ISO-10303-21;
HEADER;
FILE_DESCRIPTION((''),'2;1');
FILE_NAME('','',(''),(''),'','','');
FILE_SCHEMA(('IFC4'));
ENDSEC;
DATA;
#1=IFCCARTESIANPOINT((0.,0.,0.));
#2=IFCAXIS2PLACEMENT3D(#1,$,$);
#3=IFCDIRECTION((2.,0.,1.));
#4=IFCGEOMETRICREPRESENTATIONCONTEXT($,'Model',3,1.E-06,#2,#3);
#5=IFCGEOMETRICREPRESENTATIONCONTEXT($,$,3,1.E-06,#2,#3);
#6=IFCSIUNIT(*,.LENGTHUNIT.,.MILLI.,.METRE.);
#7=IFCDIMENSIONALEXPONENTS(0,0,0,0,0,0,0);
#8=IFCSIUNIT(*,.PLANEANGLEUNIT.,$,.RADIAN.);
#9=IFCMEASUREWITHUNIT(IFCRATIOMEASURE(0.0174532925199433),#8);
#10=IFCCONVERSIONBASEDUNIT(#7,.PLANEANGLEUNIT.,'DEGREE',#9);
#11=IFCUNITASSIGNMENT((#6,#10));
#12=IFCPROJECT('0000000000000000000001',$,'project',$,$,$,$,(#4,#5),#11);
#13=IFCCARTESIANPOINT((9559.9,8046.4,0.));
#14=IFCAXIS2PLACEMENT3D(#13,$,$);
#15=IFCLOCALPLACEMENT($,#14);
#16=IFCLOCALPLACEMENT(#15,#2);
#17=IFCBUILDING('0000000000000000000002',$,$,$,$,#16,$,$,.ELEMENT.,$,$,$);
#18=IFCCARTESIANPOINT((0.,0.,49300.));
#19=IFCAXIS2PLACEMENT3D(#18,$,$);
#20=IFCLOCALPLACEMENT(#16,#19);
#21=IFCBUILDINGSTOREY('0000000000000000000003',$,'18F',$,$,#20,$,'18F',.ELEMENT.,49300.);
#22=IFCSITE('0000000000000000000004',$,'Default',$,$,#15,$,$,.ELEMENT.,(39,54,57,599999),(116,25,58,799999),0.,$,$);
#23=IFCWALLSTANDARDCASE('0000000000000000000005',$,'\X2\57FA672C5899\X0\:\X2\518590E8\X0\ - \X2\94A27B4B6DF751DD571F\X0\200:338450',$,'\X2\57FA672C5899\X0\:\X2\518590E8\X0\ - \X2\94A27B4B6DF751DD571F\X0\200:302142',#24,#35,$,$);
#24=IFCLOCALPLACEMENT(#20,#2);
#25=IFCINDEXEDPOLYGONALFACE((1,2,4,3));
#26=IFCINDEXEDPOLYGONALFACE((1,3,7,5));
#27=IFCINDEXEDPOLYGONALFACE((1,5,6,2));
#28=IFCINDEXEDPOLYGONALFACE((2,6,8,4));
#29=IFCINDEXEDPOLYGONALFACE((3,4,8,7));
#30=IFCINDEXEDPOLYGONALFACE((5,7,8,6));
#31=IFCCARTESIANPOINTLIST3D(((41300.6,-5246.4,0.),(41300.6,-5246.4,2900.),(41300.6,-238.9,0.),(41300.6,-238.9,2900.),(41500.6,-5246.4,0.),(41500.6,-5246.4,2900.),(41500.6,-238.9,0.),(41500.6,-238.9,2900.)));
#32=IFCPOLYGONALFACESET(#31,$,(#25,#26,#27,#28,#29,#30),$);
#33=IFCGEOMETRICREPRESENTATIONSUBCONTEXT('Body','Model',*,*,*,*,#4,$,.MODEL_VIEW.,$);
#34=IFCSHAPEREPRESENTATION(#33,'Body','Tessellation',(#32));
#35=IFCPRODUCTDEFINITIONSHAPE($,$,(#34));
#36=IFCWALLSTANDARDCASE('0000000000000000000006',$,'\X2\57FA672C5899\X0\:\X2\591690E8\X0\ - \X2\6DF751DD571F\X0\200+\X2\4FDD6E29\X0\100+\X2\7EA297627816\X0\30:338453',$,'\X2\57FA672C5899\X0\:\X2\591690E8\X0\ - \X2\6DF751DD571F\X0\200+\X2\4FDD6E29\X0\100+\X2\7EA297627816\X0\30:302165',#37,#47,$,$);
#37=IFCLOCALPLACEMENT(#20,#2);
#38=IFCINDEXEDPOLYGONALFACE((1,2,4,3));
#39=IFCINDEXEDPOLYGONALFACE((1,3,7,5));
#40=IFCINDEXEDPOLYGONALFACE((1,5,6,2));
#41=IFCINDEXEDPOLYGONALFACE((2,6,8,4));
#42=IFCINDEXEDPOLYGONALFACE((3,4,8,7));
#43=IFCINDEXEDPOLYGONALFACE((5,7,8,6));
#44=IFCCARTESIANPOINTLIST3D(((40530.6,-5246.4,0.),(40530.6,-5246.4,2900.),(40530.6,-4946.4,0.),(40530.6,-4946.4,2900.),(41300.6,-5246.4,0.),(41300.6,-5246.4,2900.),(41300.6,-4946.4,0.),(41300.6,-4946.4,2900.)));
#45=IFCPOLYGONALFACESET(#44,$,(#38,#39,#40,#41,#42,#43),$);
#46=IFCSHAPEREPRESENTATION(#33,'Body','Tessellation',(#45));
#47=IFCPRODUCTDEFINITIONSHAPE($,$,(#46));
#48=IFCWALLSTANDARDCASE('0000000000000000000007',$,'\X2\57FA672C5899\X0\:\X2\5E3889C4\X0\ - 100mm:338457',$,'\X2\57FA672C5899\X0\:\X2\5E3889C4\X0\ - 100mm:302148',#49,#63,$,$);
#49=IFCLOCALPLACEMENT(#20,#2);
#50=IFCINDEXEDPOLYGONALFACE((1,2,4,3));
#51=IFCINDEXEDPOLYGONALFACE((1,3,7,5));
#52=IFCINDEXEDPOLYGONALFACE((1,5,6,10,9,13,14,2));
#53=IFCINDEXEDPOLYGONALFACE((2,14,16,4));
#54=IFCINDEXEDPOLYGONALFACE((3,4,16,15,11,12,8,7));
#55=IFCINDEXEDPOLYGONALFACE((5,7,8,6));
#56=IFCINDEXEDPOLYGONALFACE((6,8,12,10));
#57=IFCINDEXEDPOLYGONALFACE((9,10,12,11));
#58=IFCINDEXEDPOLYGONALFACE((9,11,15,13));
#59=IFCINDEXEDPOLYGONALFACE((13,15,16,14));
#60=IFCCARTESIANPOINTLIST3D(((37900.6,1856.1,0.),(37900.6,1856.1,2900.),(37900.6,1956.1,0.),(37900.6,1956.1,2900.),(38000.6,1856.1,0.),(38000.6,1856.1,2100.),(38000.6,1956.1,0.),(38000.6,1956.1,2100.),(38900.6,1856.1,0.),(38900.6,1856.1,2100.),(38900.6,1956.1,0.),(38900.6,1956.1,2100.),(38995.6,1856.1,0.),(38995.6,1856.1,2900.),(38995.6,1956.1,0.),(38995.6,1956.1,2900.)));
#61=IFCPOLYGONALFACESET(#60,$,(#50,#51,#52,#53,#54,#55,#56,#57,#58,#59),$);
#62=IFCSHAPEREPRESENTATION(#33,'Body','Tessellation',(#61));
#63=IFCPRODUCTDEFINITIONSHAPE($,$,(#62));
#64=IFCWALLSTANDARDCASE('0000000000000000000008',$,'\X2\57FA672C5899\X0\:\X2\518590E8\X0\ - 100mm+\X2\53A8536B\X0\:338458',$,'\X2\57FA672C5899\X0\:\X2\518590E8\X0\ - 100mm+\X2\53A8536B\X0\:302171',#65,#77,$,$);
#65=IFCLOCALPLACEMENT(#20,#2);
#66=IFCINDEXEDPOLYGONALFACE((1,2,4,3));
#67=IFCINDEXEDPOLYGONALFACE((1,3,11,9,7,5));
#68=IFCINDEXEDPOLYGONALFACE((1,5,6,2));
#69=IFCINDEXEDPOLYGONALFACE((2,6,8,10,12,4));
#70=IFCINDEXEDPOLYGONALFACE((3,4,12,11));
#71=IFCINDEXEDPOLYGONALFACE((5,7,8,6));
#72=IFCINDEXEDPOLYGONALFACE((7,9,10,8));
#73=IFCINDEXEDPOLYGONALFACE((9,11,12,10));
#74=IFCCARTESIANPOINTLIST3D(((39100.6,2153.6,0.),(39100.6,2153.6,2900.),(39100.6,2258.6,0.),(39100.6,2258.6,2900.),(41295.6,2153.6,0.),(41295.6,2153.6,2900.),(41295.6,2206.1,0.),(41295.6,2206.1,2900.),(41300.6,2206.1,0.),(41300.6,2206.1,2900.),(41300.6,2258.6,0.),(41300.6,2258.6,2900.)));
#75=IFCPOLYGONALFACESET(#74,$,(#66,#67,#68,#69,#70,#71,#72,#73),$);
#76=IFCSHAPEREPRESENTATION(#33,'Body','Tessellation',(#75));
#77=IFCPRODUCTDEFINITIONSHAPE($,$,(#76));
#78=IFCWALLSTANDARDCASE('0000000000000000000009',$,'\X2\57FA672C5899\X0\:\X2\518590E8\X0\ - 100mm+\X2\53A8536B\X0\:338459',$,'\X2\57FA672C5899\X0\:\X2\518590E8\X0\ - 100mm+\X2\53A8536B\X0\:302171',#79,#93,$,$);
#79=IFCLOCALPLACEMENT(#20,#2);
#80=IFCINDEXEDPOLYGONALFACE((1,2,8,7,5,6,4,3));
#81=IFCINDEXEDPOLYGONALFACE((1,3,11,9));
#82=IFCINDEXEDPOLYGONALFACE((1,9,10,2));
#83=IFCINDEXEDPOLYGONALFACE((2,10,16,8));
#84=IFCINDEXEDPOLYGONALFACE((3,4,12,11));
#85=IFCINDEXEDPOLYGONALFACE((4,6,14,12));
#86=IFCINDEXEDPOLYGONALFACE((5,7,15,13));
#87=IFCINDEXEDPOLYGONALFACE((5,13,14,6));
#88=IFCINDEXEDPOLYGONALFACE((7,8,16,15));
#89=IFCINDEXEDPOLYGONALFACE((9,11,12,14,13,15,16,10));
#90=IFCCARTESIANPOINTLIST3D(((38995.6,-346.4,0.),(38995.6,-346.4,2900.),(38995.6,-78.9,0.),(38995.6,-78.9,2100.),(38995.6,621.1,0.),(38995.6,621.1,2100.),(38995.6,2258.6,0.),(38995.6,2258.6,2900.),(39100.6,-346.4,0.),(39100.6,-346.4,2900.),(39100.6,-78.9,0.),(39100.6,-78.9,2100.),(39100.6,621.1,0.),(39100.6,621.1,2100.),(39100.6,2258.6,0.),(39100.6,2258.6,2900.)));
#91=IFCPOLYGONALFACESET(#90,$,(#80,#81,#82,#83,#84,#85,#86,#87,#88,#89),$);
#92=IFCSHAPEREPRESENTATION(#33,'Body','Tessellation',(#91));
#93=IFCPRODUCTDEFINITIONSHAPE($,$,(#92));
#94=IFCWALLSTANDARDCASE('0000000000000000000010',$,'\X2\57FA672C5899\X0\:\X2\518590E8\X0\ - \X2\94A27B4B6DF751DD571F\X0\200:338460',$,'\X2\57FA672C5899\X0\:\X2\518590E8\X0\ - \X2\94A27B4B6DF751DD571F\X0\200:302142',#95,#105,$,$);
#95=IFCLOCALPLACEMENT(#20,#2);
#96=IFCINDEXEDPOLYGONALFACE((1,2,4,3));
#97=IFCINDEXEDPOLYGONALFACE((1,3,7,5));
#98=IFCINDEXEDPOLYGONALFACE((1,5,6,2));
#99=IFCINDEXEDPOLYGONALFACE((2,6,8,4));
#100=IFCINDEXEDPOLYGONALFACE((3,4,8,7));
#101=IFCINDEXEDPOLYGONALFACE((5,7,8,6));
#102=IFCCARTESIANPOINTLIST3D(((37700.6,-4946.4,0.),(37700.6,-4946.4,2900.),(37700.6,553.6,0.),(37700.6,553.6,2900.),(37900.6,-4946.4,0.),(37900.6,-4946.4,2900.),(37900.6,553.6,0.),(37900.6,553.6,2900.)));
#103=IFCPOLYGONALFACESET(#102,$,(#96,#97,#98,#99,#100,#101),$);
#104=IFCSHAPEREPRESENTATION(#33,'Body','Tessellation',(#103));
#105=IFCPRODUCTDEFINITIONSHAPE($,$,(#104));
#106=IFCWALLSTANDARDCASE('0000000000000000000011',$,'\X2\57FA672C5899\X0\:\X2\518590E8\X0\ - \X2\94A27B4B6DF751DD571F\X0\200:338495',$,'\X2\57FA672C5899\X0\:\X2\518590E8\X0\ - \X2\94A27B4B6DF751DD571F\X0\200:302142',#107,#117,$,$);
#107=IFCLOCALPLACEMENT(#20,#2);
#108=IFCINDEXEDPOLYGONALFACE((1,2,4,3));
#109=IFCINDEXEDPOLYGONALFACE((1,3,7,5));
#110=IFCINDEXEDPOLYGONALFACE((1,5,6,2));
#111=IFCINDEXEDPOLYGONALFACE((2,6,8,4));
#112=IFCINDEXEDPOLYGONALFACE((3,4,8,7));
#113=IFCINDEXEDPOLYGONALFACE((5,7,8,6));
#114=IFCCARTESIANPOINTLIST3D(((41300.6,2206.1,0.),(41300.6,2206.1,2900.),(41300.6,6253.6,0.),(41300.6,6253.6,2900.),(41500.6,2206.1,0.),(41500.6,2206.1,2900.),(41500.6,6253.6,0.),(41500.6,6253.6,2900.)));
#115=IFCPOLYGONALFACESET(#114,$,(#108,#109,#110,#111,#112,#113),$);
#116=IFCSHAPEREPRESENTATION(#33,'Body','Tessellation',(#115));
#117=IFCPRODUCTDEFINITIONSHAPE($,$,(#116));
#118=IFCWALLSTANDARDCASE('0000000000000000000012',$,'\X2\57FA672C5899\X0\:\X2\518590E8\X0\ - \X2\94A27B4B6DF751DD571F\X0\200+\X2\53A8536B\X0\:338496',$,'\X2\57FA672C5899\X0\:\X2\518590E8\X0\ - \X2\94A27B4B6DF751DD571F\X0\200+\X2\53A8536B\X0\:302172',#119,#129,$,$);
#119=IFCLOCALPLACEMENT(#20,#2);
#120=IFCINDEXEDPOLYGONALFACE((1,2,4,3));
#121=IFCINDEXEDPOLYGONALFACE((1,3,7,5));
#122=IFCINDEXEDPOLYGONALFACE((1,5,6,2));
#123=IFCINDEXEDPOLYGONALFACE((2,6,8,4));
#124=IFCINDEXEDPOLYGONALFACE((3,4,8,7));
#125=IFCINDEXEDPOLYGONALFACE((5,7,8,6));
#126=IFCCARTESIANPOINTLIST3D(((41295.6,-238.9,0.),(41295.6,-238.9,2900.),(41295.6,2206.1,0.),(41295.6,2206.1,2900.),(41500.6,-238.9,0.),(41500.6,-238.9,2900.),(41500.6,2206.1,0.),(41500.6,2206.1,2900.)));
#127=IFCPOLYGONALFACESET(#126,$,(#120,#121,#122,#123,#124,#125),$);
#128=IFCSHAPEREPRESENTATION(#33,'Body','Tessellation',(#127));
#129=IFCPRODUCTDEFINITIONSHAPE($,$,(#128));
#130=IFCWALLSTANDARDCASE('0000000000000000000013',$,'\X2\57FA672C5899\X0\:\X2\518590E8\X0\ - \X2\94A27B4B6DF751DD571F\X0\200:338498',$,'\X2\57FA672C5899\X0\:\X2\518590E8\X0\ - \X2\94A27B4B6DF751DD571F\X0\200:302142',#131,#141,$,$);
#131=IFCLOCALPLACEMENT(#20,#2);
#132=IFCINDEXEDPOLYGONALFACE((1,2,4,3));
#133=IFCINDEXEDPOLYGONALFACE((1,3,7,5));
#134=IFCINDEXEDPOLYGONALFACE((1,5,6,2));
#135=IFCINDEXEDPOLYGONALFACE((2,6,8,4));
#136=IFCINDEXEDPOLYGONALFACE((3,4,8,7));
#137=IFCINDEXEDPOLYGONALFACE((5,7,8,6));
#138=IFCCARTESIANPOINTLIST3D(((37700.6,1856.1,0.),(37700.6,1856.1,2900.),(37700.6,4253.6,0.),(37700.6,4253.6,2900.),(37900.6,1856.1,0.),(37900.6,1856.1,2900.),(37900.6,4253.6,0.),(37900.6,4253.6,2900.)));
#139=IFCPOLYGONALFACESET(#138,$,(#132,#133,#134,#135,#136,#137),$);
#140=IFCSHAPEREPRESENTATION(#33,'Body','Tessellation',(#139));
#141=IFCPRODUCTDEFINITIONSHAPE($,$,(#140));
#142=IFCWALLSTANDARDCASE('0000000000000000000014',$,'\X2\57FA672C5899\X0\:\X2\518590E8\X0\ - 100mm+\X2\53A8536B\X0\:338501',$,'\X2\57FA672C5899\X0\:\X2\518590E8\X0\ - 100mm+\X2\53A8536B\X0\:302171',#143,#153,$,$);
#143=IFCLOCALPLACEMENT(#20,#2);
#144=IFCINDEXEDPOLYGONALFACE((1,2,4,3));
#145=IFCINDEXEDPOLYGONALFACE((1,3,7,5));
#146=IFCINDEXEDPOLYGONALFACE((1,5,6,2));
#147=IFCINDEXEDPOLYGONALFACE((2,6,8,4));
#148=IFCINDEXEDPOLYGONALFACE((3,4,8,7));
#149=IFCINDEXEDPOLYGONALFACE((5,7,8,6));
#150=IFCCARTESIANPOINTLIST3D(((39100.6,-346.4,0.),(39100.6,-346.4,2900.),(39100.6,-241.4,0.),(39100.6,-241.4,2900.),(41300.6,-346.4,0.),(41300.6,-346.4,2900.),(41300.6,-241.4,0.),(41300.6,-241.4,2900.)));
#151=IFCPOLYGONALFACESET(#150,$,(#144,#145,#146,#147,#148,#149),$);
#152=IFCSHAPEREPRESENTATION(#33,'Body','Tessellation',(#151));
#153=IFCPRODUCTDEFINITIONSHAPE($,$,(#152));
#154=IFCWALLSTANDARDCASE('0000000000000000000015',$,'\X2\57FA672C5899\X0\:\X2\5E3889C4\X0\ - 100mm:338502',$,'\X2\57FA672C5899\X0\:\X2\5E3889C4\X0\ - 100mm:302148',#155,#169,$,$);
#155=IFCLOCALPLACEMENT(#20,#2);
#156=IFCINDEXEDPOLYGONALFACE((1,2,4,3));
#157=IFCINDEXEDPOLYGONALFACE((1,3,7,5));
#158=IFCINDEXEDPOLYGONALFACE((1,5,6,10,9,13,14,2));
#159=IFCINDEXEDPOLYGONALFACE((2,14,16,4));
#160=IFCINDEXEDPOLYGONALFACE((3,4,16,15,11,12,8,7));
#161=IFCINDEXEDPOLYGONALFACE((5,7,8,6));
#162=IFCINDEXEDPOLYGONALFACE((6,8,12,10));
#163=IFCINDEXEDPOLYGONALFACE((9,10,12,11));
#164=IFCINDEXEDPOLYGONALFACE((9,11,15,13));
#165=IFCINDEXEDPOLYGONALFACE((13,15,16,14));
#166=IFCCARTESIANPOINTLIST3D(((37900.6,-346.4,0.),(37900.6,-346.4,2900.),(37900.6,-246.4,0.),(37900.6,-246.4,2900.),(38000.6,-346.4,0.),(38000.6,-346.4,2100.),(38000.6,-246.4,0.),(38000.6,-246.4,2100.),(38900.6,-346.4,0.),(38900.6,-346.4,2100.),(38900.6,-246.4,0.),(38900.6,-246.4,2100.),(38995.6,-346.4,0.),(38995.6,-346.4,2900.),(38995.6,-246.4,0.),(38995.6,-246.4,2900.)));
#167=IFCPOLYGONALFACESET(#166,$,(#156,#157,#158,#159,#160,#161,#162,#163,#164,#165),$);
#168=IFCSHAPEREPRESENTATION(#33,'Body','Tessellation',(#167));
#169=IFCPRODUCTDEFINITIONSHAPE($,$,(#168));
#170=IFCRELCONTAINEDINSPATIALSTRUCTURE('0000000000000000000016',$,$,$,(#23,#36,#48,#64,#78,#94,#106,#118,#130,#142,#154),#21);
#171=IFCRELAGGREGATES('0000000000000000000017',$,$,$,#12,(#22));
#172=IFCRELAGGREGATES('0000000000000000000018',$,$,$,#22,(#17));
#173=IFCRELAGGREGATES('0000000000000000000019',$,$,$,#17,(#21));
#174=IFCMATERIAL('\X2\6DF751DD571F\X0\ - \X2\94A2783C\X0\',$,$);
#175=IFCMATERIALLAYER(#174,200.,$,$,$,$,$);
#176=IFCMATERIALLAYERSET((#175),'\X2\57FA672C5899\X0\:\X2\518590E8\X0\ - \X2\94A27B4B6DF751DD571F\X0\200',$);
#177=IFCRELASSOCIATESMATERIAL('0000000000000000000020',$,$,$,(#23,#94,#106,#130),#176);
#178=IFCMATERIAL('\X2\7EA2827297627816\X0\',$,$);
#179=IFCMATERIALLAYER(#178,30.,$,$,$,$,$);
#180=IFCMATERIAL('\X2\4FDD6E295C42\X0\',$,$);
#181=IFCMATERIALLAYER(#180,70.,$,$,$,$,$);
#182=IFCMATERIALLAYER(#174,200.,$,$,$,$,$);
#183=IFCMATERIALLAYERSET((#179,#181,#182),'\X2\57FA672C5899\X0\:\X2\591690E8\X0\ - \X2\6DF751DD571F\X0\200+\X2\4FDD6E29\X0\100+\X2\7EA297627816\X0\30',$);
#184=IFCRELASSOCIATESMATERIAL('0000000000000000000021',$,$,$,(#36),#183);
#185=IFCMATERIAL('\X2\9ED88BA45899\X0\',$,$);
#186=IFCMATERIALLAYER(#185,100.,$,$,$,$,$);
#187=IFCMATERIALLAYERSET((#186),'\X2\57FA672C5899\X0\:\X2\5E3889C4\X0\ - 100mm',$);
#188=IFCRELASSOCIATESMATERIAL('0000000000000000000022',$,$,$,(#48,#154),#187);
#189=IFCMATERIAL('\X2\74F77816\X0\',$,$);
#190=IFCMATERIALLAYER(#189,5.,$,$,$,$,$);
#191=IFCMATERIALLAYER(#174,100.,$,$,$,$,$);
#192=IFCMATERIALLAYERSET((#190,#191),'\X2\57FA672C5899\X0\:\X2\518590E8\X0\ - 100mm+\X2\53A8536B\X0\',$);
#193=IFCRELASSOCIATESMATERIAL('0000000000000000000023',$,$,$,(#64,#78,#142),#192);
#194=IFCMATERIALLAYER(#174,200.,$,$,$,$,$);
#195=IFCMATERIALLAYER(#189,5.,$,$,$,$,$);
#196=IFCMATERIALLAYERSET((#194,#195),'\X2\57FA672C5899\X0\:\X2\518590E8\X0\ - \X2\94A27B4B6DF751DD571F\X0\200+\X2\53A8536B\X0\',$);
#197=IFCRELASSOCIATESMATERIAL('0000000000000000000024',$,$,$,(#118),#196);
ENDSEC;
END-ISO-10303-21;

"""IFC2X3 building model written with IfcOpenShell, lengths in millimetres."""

from ifc_helpers import new_model, entity, si_unit, converted_unit, direction, frame, frame_2d, origin, place, context, subcontext, project, spatial, polyline, rectangle, outline, extrude, material, layer, layer_set, layer_usage, element, save


model = new_model("IFC2X3")

# Units and contexts
model_context = context("Model", 3, precision=1e-06, world=origin(), true_north=direction((2.0, 0.0, 1.0)))
context_of_model = context(None, 3, precision=1e-06, world=origin(), true_north=direction((2.0, 0.0, 1.0)))
body_context = subcontext(model_context, "Body", "Model", "MODEL_VIEW")
ifc_project = project(units=[si_unit("LENGTHUNIT", "METRE", prefix="MILLI"), converted_unit("PLANEANGLEUNIT", "DEGREE", entity("IfcRatioMeasure", 0.0174532925199433), si_unit("PLANEANGLEUNIT", "RADIAN"), dimensions=[0, 0, 0, 0, 0, 0, 0])], contexts=[model_context, context_of_model])

# Site, building, storey
site_placement = place(None, frame((9559.9, 8046.4, 0.0)))
site = spatial("IfcSite", under=ifc_project, at=site_placement, Name="Default", CompositionType="ELEMENT", RefLatitude=(39, 54, 57, 599999), RefLongitude=(116, 25, 58, 799999), RefElevation=0.0)
building_placement = place(site_placement, origin())
building = spatial("IfcBuilding", under=site, at=building_placement, CompositionType="ELEMENT")
storey_placement = place(building_placement, frame((0.0, 0.0, 49300.0)))
storey = spatial("IfcBuildingStorey", under=building, at=storey_placement, Name="18F", LongName="18F", CompositionType="ELEMENT", Elevation=49300.0)

# Walls
ifc_material_1 = material(Name="混凝土 - 钢砼")
ifc_layer_1 = layer(ifc_material_1, 200.0)
ifc_layer_set_1 = layer_set([ifc_layer_1], Name="基本墙:内部 - 钢筋混凝土200")
ifc_layer_usage_1 = layer_usage(ifc_layer_set_1, "AXIS2", "POSITIVE", -100.0)
wall_1_placement = place(storey_placement, frame((41400.6, -5246.4, 0.0), z_axis=(0.0, 0.0, 1.0), x_axis=(0.0, 1.0, 0.0)))
element("IfcWallStandardCase", 1, at=wall_1_placement, inside=storey, material=ifc_layer_usage_1, Name="基本墙:内部 - 钢筋混凝土200:338450", ObjectType="基本墙:内部 - 钢筋混凝土200:302142", context=body_context, shape_type="SweptSolid", body=[
    extrude(rectangle(XDim=5007.5, YDim=200.0, at=frame_2d((2503.8, 0.0), x_axis=(-1.0, 0.0))), origin(), (0.0, 0.0, 1.0), 2900.0),
])
ifc_material_2 = material(Name="红色面砖")
ifc_layer_2 = layer(ifc_material_2, 30.0)
ifc_material_3 = material(Name="保温层")
ifc_layer_3 = layer(ifc_material_3, 70.0)
ifc_layer_4 = layer(ifc_material_1, 200.0)
ifc_layer_set_2 = layer_set([ifc_layer_2, ifc_layer_3, ifc_layer_4], Name="基本墙:外部 - 混凝土200+保温100+红面砖30")
ifc_layer_usage_2 = layer_usage(ifc_layer_set_2, "AXIS2", "NEGATIVE", 150.0)
wall_2_placement = place(storey_placement, frame((41300.6, -5096.4, 0.0), z_axis=(0.0, 0.0, 1.0), x_axis=(-1.0, 0.0, 0.0)))
element("IfcWallStandardCase", 2, at=wall_2_placement, inside=storey, material=ifc_layer_usage_2, Name="基本墙:外部 - 混凝土200+保温100+红面砖30:338453", ObjectType="基本墙:外部 - 混凝土200+保温100+红面砖30:302165", context=body_context, shape_type="SweptSolid", body=[
    extrude(rectangle(XDim=770.0, YDim=300.0, at=frame_2d((385.0, 0.0), x_axis=(-1.0, 0.0))), origin(), (0.0, 0.0, 1.0), 2900.0),
])

# Wall, opening
ifc_material_4 = material(Name="默认墙")
ifc_layer_5 = layer(ifc_material_4, 100.0)
ifc_layer_set_3 = layer_set([ifc_layer_5], Name="基本墙:常规 - 100mm")
ifc_layer_usage_3 = layer_usage(ifc_layer_set_3, "AXIS2", "POSITIVE", -50.0)
wall_3_placement = place(storey_placement, frame((38995.6, 1906.1, 0.0), z_axis=(0.0, 0.0, 1.0), x_axis=(-1.0, 0.0, 0.0)))
wall_3 = element("IfcWallStandardCase", 3, at=wall_3_placement, inside=storey, material=ifc_layer_usage_3, Name="基本墙:常规 - 100mm:338457", ObjectType="基本墙:常规 - 100mm:302148", context=body_context, shape_type="SweptSolid", body=[
    extrude(rectangle(XDim=1095.0, YDim=100.0, at=frame_2d((547.5, 0.0), x_axis=(-1.0, 0.0))), origin(), (0.0, 0.0, 1.0), 2900.0),
])
opening_1_placement = place(wall_3_placement, frame((995.0, 50.0, 0.0)))
element("IfcOpeningElement", 4, at=opening_1_placement, cuts=wall_3, ObjectType="Opening", context=body_context, shape_type="SweptSolid", body=[
    extrude(rectangle(XDim=2100.0, YDim=900.0, at=frame_2d((1050.0, 450.0), x_axis=(1.0, 0.0))), frame((0.0, 0.0, 0.0), z_axis=(0.0, -1.0, 0.0), x_axis=(0.0, 0.0, 1.0)), (0.0, 0.0, 1.0), 100.0),
])

# Wall
ifc_material_5 = material(Name="瓷砖")
ifc_layer_6 = layer(ifc_material_5, 5.0)
ifc_layer_7 = layer(ifc_material_1, 100.0)
ifc_layer_set_4 = layer_set([ifc_layer_6, ifc_layer_7], Name="基本墙:内部 - 100mm+厨卫")
ifc_layer_usage_4 = layer_usage(ifc_layer_set_4, "AXIS2", "NEGATIVE", 52.5)
wall_4_placement = place(storey_placement, frame((41300.6, 2206.1, 0.0), z_axis=(0.0, 0.0, 1.0), x_axis=(-1.0, 0.0, 0.0)))
element("IfcWallStandardCase", 5, at=wall_4_placement, inside=storey, material=ifc_layer_usage_4, Name="基本墙:内部 - 100mm+厨卫:338458", ObjectType="基本墙:内部 - 100mm+厨卫:302171", context=body_context, shape_type="SweptSolid", body=[
    extrude(outline(polyline([(2200.0, -52.5), (2200.0, 52.5), (5.0, 52.5), (5.0, 0.0), (0.0, 0.0), (0.0, -52.5), (2200.0, -52.5)])), origin(), (0.0, 0.0, 1.0), 2900.0),
])

# Wall, opening
ifc_layer_usage_5 = layer_usage(ifc_layer_set_4, "AXIS2", "NEGATIVE", 52.5)
wall_5_placement = place(storey_placement, frame((39048.1, 2258.6, 0.0), z_axis=(0.0, 0.0, 1.0), x_axis=(0.0, -1.0, 0.0)))
wall_5 = element("IfcWallStandardCase", 6, at=wall_5_placement, inside=storey, material=ifc_layer_usage_5, Name="基本墙:内部 - 100mm+厨卫:338459", ObjectType="基本墙:内部 - 100mm+厨卫:302171", context=body_context, shape_type="SweptSolid", body=[
    extrude(rectangle(XDim=2605.0, YDim=105.0, at=frame_2d((1302.5, 0.0), x_axis=(-1.0, 0.0))), origin(), (0.0, 0.0, 1.0), 2900.0),
])
opening_2_placement = place(wall_5_placement, frame((1637.5, -52.5, 0.0)))
element("IfcOpeningElement", 7, at=opening_2_placement, cuts=wall_5, ObjectType="Opening", context=body_context, shape_type="SweptSolid", body=[
    extrude(rectangle(XDim=2100.0, YDim=700.0, at=frame_2d((1050.0, 350.0), x_axis=(1.0, 0.0))), frame((0.0, 0.0, 0.0), z_axis=(0.0, 1.0, 0.0), x_axis=(0.0, 0.0, 1.0)), (0.0, 0.0, 1.0), 105.0),
])

# Walls
ifc_layer_usage_6 = layer_usage(ifc_layer_set_1, "AXIS2", "NEGATIVE", 100.0)
wall_6_placement = place(storey_placement, frame((37800.6, 553.6, 0.0), z_axis=(0.0, 0.0, 1.0), x_axis=(0.0, -1.0, 0.0)))
element("IfcWallStandardCase", 8, at=wall_6_placement, inside=storey, material=ifc_layer_usage_6, Name="基本墙:内部 - 钢筋混凝土200:338460", ObjectType="基本墙:内部 - 钢筋混凝土200:302142", context=body_context, shape_type="SweptSolid", body=[
    extrude(rectangle(XDim=5500.0, YDim=200.0, at=frame_2d((2750.0, 0.0), x_axis=(-1.0, 0.0))), origin(), (0.0, 0.0, 1.0), 2900.0),
])
ifc_layer_usage_7 = layer_usage(ifc_layer_set_1, "AXIS2", "POSITIVE", -100.0)
wall_7_placement = place(storey_placement, frame((41400.6, 2206.1, 0.0), z_axis=(0.0, 0.0, 1.0), x_axis=(0.0, 1.0, 0.0)))
element("IfcWallStandardCase", 9, at=wall_7_placement, inside=storey, material=ifc_layer_usage_7, Name="基本墙:内部 - 钢筋混凝土200:338495", ObjectType="基本墙:内部 - 钢筋混凝土200:302142", context=body_context, shape_type="SweptSolid", body=[
    extrude(rectangle(XDim=4047.5, YDim=200.0, at=frame_2d((2023.8, 0.0), x_axis=(-1.0, 0.0))), origin(), (0.0, 0.0, 1.0), 2900.0),
])
ifc_layer_8 = layer(ifc_material_1, 200.0)
ifc_layer_9 = layer(ifc_material_5, 5.0)
ifc_layer_set_5 = layer_set([ifc_layer_8, ifc_layer_9], Name="基本墙:内部 - 钢筋混凝土200+厨卫")
ifc_layer_usage_8 = layer_usage(ifc_layer_set_5, "AXIS2", "POSITIVE", -102.5)
wall_8_placement = place(storey_placement, frame((41398.1, -238.9, 0.0), z_axis=(0.0, 0.0, 1.0), x_axis=(0.0, 1.0, 0.0)))
element("IfcWallStandardCase", 10, at=wall_8_placement, inside=storey, material=ifc_layer_usage_8, Name="基本墙:内部 - 钢筋混凝土200+厨卫:338496", ObjectType="基本墙:内部 - 钢筋混凝土200+厨卫:302172", context=body_context, shape_type="SweptSolid", body=[
    extrude(rectangle(XDim=2445.0, YDim=205.0, at=frame_2d((1222.5, 0.0), x_axis=(-1.0, 0.0))), origin(), (0.0, 0.0, 1.0), 2900.0),
])
ifc_layer_usage_9 = layer_usage(ifc_layer_set_1, "AXIS2", "POSITIVE", -100.0)
wall_9_placement = place(storey_placement, frame((37800.6, 4253.6, 0.0), z_axis=(0.0, 0.0, 1.0), x_axis=(0.0, -1.0, 0.0)))
element("IfcWallStandardCase", 11, at=wall_9_placement, inside=storey, material=ifc_layer_usage_9, Name="基本墙:内部 - 钢筋混凝土200:338498", ObjectType="基本墙:内部 - 钢筋混凝土200:302142", context=body_context, shape_type="SweptSolid", body=[
    extrude(rectangle(XDim=2397.5, YDim=200.0, at=frame_2d((1198.8, 0.0), x_axis=(-1.0, 0.0))), origin(), (0.0, 0.0, 1.0), 2900.0),
])
ifc_layer_usage_10 = layer_usage(ifc_layer_set_4, "AXIS2", "POSITIVE", -52.5)
wall_10_placement = place(storey_placement, frame((41300.6, -293.9, 0.0), z_axis=(0.0, 0.0, 1.0), x_axis=(-1.0, 0.0, 0.0)))
element("IfcWallStandardCase", 12, at=wall_10_placement, inside=storey, material=ifc_layer_usage_10, Name="基本墙:内部 - 100mm+厨卫:338501", ObjectType="基本墙:内部 - 100mm+厨卫:302171", context=body_context, shape_type="SweptSolid", body=[
    extrude(rectangle(XDim=2200.0, YDim=105.0, at=frame_2d((1100.0, 0.0), x_axis=(-1.0, 0.0))), origin(), (0.0, 0.0, 1.0), 2900.0),
])

# Wall, opening
ifc_layer_usage_11 = layer_usage(ifc_layer_set_3, "AXIS2", "POSITIVE", -50.0)
wall_11_placement = place(storey_placement, frame((38995.6, -296.4, 0.0), z_axis=(0.0, 0.0, 1.0), x_axis=(-1.0, 0.0, 0.0)))
wall_11 = element("IfcWallStandardCase", 13, at=wall_11_placement, inside=storey, material=ifc_layer_usage_11, Name="基本墙:常规 - 100mm:338502", ObjectType="基本墙:常规 - 100mm:302148", context=body_context, shape_type="SweptSolid", body=[
    extrude(rectangle(XDim=1095.0, YDim=100.0, at=frame_2d((547.5, 0.0), x_axis=(-1.0, 0.0))), origin(), (0.0, 0.0, 1.0), 2900.0),
])
opening_3_placement = place(wall_11_placement, frame((95.0, -50.0, 0.0)))
element("IfcOpeningElement", 14, at=opening_3_placement, cuts=wall_11, ObjectType="Opening", context=body_context, shape_type="SweptSolid", body=[
    extrude(rectangle(XDim=2100.0, YDim=900.0, at=frame_2d((1050.0, 450.0), x_axis=(1.0, 0.0))), frame((0.0, 0.0, 0.0), z_axis=(0.0, 1.0, 0.0), x_axis=(0.0, 0.0, 1.0)), (0.0, 0.0, 1.0), 100.0),
])

save(model, "model.ifc")
